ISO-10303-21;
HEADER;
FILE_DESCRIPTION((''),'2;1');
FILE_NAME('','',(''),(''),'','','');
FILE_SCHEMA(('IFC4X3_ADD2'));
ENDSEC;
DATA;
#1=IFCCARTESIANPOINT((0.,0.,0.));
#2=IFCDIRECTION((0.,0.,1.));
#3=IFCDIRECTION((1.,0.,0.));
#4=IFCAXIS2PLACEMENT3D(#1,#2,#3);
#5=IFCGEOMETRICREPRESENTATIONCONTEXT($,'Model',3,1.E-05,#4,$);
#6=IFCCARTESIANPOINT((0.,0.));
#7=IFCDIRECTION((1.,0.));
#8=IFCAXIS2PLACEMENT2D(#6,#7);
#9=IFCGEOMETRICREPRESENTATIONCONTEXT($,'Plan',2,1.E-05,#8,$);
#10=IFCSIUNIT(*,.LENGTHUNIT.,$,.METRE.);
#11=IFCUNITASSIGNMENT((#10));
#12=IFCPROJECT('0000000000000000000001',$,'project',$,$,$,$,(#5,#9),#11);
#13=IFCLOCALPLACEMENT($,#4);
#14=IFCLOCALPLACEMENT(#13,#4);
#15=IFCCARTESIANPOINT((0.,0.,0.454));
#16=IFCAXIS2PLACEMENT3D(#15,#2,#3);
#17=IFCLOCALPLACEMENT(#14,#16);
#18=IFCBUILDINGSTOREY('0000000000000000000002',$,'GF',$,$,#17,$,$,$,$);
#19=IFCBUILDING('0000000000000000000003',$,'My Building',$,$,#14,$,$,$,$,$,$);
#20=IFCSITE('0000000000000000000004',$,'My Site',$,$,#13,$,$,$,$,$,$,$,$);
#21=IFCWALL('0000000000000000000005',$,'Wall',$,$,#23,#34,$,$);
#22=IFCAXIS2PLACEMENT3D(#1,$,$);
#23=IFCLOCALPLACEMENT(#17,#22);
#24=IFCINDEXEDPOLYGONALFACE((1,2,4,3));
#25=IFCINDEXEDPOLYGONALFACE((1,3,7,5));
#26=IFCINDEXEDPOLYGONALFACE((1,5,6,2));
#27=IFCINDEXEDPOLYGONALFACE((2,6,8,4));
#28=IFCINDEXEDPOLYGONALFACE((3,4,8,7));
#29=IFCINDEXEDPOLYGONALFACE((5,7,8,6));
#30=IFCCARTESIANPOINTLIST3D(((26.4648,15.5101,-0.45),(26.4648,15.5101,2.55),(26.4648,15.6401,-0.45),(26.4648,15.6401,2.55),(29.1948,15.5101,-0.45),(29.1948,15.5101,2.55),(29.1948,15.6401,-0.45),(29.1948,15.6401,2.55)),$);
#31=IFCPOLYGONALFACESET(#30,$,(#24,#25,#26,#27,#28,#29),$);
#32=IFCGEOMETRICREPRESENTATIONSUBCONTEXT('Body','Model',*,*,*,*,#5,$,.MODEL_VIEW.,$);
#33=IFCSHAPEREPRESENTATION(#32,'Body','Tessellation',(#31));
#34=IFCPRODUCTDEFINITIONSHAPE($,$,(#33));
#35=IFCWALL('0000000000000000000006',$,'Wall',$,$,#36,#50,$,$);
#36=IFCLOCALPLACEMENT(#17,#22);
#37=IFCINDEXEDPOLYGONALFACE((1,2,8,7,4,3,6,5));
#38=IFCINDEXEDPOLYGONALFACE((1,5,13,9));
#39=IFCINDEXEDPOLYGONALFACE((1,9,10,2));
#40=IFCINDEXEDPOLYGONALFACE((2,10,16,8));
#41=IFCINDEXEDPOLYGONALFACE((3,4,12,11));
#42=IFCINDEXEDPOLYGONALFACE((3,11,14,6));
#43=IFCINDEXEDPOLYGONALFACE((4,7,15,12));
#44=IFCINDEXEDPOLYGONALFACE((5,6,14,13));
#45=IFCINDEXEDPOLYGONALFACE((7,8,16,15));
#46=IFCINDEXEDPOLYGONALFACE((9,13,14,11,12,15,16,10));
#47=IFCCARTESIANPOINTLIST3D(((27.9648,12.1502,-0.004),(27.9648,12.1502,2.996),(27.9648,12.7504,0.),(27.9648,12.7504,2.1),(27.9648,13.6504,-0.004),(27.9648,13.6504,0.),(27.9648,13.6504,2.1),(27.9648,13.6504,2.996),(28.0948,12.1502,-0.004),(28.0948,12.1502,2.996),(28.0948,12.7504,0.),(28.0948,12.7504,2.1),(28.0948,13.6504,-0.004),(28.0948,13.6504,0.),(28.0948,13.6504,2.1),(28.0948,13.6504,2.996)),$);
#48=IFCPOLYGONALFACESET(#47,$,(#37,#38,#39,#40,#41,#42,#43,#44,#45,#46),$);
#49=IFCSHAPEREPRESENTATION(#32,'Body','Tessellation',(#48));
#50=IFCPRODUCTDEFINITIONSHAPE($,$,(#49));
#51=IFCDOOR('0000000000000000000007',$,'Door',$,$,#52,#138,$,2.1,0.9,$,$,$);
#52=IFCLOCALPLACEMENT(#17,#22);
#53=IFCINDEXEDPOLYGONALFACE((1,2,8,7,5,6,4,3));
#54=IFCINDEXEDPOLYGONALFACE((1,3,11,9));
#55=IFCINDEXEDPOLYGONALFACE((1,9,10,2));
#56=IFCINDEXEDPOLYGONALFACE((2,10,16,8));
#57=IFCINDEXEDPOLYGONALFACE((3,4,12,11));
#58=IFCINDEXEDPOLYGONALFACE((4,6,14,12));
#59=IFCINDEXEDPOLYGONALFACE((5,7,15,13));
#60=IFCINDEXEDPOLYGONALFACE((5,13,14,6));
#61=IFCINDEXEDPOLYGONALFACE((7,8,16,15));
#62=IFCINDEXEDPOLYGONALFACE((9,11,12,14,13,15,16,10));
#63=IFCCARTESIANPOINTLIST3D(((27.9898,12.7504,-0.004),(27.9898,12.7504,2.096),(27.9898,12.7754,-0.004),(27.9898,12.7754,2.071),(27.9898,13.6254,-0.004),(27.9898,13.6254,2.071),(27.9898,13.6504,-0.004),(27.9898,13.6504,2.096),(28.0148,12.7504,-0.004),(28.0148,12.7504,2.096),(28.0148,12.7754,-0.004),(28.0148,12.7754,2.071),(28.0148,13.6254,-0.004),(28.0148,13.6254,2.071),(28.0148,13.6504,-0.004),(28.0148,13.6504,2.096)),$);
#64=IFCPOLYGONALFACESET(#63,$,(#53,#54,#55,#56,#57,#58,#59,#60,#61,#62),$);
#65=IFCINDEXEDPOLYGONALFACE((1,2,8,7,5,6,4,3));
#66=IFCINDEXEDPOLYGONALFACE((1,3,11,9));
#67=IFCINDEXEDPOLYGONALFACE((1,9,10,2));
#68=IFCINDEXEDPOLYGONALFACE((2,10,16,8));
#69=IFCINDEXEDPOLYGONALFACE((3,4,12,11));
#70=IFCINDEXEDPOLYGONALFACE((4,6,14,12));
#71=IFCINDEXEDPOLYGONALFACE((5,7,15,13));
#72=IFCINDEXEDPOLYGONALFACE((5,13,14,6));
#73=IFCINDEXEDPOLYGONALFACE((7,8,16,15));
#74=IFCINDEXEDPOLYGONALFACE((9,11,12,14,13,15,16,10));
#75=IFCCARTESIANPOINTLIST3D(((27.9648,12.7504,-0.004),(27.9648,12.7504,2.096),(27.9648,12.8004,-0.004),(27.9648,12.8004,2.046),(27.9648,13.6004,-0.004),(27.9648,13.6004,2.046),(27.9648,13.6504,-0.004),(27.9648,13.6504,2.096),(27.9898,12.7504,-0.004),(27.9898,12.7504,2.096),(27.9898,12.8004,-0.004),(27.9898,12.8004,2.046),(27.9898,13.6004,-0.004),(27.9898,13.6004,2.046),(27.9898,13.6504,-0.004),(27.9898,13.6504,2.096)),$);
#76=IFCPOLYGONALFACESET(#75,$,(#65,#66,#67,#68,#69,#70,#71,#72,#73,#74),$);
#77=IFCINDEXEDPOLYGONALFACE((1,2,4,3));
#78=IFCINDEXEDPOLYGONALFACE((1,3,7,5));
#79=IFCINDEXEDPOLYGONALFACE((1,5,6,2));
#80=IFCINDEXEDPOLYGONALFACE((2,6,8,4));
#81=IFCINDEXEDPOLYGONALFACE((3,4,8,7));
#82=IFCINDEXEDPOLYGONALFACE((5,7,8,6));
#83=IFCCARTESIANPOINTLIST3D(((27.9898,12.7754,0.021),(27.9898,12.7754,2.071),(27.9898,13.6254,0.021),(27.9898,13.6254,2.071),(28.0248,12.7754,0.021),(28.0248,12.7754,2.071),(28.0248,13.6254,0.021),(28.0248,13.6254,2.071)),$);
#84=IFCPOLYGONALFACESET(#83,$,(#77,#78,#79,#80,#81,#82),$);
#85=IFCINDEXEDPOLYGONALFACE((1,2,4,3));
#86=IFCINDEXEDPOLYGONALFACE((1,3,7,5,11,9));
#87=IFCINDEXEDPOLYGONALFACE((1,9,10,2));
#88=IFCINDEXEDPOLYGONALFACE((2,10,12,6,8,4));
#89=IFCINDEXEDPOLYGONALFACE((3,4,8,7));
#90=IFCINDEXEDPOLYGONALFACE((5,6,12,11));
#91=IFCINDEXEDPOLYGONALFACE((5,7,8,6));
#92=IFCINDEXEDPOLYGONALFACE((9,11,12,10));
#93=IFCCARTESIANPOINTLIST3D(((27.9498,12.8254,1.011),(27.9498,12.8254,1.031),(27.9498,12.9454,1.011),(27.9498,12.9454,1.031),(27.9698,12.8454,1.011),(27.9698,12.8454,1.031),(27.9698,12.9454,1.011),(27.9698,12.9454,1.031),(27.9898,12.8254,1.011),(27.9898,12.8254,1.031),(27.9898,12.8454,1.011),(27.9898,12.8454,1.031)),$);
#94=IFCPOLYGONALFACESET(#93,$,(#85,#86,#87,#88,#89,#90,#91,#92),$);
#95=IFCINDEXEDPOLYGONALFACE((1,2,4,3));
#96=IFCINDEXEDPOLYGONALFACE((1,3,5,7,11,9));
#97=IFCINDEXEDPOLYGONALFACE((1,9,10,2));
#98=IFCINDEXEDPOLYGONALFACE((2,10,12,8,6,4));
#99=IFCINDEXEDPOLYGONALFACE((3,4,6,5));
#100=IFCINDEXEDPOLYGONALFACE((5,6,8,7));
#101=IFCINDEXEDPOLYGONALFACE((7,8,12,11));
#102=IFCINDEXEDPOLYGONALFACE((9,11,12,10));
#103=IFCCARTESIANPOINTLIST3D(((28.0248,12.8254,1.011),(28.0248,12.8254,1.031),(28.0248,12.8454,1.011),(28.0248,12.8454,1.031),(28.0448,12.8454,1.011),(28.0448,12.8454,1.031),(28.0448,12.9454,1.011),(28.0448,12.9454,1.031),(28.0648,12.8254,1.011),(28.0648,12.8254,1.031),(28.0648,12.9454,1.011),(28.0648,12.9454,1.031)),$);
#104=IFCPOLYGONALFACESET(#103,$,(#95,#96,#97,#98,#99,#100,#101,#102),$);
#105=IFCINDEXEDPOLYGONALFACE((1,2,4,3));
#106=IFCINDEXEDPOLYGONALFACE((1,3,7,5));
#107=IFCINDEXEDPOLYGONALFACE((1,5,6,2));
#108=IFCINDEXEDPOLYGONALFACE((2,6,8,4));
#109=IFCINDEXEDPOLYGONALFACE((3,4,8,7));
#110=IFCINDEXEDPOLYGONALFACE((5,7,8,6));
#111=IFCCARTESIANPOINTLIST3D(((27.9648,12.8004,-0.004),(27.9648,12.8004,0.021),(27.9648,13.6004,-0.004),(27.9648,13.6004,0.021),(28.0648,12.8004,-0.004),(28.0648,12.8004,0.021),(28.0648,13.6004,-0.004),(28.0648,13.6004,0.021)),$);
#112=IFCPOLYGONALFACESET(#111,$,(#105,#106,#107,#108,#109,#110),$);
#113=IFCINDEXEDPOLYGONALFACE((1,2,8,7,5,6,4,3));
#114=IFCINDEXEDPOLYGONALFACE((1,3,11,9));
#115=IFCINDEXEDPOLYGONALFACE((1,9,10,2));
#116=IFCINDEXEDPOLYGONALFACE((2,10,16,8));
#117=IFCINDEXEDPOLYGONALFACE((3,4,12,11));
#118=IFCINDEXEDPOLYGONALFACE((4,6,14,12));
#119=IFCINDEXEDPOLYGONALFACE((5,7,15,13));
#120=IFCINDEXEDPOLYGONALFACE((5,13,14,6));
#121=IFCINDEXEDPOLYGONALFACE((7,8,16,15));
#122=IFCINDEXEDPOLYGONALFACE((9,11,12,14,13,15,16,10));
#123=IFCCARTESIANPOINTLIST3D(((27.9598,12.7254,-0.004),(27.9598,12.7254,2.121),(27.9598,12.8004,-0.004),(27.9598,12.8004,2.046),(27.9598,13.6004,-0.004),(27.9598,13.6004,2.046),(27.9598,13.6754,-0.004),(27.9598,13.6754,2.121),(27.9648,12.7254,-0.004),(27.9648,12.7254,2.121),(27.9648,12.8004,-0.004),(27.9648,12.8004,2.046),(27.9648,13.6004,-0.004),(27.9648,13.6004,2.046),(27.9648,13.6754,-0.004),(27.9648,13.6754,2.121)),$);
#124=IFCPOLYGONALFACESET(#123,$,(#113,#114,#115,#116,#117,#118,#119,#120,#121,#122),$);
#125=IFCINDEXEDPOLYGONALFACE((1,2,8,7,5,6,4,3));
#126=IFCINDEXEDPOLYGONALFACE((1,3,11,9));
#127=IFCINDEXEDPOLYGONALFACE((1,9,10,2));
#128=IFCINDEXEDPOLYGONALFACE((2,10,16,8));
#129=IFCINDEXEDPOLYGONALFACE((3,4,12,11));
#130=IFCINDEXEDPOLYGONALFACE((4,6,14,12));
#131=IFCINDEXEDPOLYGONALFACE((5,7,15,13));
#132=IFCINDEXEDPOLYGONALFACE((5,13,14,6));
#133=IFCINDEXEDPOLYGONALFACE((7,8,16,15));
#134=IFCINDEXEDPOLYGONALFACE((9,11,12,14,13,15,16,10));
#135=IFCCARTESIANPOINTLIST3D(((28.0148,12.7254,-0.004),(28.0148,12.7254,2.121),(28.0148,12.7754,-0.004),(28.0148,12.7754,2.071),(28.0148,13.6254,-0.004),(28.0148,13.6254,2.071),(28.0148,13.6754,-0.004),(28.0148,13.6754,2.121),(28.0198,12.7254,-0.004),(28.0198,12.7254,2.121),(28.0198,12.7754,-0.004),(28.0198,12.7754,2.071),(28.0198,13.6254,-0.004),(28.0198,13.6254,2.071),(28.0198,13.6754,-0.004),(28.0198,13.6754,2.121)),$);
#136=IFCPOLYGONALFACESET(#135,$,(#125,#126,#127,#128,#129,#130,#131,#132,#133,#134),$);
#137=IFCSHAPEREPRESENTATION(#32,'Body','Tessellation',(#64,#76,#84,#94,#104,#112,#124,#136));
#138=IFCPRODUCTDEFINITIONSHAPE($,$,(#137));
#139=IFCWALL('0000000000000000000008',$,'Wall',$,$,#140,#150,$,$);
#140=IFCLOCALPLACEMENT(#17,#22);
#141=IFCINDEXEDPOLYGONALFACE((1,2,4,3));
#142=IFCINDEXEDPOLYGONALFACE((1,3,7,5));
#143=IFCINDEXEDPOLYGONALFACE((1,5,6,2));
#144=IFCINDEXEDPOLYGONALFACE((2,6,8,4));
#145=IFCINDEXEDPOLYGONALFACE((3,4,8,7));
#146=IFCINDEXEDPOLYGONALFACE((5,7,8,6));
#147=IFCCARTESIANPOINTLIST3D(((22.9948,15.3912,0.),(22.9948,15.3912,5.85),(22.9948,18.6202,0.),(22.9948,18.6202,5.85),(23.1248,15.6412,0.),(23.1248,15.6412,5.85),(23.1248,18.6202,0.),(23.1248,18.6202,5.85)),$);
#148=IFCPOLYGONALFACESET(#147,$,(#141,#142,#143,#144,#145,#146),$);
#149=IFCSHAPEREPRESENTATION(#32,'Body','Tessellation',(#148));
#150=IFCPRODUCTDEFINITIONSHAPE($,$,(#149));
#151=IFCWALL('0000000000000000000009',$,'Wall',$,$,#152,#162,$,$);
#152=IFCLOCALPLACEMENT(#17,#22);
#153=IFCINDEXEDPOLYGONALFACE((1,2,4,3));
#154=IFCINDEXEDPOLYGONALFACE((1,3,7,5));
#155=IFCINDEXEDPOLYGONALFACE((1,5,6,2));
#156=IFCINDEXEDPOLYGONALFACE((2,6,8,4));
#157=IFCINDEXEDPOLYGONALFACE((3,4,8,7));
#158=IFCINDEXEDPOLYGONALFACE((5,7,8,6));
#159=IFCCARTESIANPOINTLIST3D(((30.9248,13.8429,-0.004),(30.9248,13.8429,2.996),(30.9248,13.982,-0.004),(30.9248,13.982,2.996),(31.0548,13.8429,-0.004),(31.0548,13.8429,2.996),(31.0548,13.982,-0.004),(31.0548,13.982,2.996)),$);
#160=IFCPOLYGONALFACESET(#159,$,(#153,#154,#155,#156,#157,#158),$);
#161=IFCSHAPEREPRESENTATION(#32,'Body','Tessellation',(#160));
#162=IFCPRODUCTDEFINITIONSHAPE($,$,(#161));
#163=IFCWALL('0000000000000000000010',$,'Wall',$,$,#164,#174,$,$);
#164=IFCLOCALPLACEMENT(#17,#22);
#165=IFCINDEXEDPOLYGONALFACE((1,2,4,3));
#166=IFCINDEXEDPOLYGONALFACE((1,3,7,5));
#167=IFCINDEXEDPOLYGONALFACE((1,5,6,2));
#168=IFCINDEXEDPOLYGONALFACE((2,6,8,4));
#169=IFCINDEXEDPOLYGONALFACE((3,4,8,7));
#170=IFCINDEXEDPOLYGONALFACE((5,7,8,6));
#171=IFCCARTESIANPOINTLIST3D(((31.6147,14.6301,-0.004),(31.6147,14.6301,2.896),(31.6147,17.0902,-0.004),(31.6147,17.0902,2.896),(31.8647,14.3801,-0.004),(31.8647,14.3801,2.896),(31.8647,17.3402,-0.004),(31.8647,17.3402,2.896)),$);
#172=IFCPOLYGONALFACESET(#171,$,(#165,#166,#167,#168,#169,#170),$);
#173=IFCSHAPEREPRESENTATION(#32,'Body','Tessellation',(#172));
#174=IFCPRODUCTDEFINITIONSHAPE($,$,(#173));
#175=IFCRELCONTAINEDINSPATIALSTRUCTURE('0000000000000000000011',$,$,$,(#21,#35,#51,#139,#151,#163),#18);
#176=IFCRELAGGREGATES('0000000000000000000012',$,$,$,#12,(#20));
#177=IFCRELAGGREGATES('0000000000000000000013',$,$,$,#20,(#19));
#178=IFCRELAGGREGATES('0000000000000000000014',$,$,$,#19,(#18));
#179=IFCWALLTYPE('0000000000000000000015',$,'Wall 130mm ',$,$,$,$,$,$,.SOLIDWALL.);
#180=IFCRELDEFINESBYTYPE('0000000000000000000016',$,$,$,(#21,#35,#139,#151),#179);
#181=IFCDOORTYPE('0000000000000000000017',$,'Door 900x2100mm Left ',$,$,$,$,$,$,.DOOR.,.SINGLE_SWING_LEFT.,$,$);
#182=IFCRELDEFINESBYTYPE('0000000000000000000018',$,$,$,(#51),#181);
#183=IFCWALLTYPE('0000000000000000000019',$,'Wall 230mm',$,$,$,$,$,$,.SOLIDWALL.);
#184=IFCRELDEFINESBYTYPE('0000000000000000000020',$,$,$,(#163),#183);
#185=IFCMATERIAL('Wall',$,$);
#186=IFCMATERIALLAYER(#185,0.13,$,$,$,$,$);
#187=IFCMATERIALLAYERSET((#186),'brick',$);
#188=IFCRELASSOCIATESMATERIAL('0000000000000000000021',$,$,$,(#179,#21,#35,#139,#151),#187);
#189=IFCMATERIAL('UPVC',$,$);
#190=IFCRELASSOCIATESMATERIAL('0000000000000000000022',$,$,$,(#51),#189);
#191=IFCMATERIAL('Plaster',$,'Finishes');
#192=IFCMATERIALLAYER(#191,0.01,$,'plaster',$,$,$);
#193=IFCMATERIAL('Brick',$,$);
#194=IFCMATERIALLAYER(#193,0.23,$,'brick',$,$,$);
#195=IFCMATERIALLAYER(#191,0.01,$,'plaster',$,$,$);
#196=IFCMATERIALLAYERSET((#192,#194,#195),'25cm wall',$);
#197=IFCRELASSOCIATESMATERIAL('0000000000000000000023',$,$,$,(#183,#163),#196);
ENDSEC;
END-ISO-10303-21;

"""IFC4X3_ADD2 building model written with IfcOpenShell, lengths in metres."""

from ifc_helpers import new_model, entity, si_unit, frame, origin_with_axes, origin_2d_with_axis, place, context, subcontext, project, spatial, line, indexed_curve, outline, extrude, shape, source, transform, mapped, material, layer, layer_set, layer_usage, type_object, type_shapes, element, fill, save


model = new_model("IFC4X3_ADD2")

# Units and contexts
model_context = context("Model", 3, precision=1e-05, world=origin_with_axes())
plan_context = context("Plan", 2, precision=1e-05, world=origin_2d_with_axis())
body_context_1 = subcontext(model_context, "Body", "Model", "MODEL_VIEW")
body_context_2 = subcontext(plan_context, "Body", "Plan", "PLAN_VIEW")
ifc_project = project(units=[si_unit("LENGTHUNIT", "METRE")], contexts=[model_context, plan_context])

# Site, building, storey
site_placement = place(None, origin_with_axes())
site = spatial("IfcSite", under=ifc_project, at=site_placement, Name="My Site")
building_placement = place(site_placement, origin_with_axes())
building = spatial("IfcBuilding", under=site, at=building_placement, Name="My Building")
storey_placement = place(building_placement, frame((0.0, 0.0, 0.454), z_axis=(0.0, 0.0, 1.0), x_axis=(1.0, 0.0, 0.0)))
storey = spatial("IfcBuildingStorey", under=building, at=storey_placement, Name="GF")

# Wall
ifc_material_1 = material(Name="Wall")
ifc_layer_1 = layer(ifc_material_1, 0.13)
ifc_layer_set_1 = layer_set([ifc_layer_1], Name="brick")
wall_type_1 = type_object("IfcWallType", Name="Wall 130mm ", PredefinedType="SOLIDWALL", material=ifc_layer_set_1)
ifc_layer_usage_1 = layer_usage(ifc_layer_set_1, "AXIS2", "POSITIVE", 0.0)
wall_1_placement = place(storey_placement, frame((29.1948, 15.6401, -0.45), z_axis=(0.0, 0.0, 1.0), x_axis=(-1.0, 0.0, 0.0)))
element("IfcWall", 1, at=wall_1_placement, inside=storey, type_object=wall_type_1, material=ifc_layer_usage_1, Name="Wall", context=body_context_1, shape_type="SweptSolid", body=[
    extrude(outline(indexed_curve([(0.0, 0.0), (0.0, 0.13), (2.73, 0.13), (2.73, 0.0), (0.0, 0.0)], self_intersect=False)), origin_with_axes(), (0.0, 0.0, 1.0), 3.0),
])

# Wall, opening, door
ifc_layer_usage_2 = layer_usage(ifc_layer_set_1, "AXIS2", "POSITIVE", 0.0)
wall_2_placement = place(storey_placement, frame((27.9648, 13.6504, -0.004), z_axis=(0.0, 0.0, 1.0), x_axis=(0.0, -1.0, 0.0)))
wall_2 = element("IfcWall", 2, at=wall_2_placement, inside=storey, type_object=wall_type_1, material=ifc_layer_usage_2, Name="Wall", context=body_context_1, shape_type="SweptSolid", body=[
    extrude(outline(indexed_curve([(0.0, 0.0), (0.0, 0.13), (1.5002, 0.13), (1.5002, 0.0), (0.0, 0.0)], self_intersect=False)), origin_with_axes(), (0.0, 0.0, 1.0), 3.0),
])
shared_shape_1 = source(origin_with_axes(), body_context_1, "Body", "SweptSolid", [
    extrude(outline(indexed_curve([(0.0, 0.0), (0.9, 0.0), (0.9, 2.1), (0.0, 2.1)], segments=[line(1, 2, 3, 4, 1)])), frame((0.0, -0.6, 0.0), z_axis=(0.0, -1.0, 0.0), x_axis=(1.0, 0.0, 0.0)), (0.0, 0.0, -1.0), 1.2),
])
opening_1_placement = place(wall_2_placement, frame((0.0, 0.0, 0.004), z_axis=(0.0, 0.0, 1.0), x_axis=(1.0, 0.0, 0.0)))
opening_1 = element("IfcOpeningElement", 3, at=opening_1_placement, cuts=wall_2, PredefinedType="OPENING", context=body_context_1, shape_type="MappedRepresentation", body=[
    mapped(shared_shape_1, transform((0.0, 0.0, 0.0), x_axis=(1.0, 0.0, 0.0), y_axis=(0.0, 1.0, 0.0), z_axis=(0.0, 0.0, 1.0), scale=1.0)),
])
ifc_material_2 = material(Name="UPVC")
door_type_1 = type_object("IfcDoorType", Name="Door 900x2100mm Left ", OperationType="SINGLE_SWING_LEFT", PredefinedType="DOOR")
shared_shape_2 = source(origin_with_axes(), body_context_1, "Body", "SweptSolid", [
    extrude(outline(indexed_curve([(0.0, 0.0), (0.0, 2.1), (0.9, 2.1), (0.9, 0.0), (0.875, 0.0), (0.875, 2.075), (0.025, 2.075), (0.025, 0.0)], segments=[line(1, 2, 3, 4, 5, 6, 7, 8, 1)])), frame((0.0, 0.025, 0.0), z_axis=(0.0, -1.0, 0.0), x_axis=(1.0, 0.0, 0.0)), (0.0, 0.0, -1.0), 0.025),
    extrude(outline(indexed_curve([(0.0, 0.0), (0.0, 2.1), (0.9, 2.1), (0.9, 0.0), (0.85, 0.0), (0.85, 2.05), (0.05, 2.05), (0.05, 0.0)], segments=[line(1, 2, 3, 4, 5, 6, 7, 8, 1)])), frame((0.0, 0.0, 0.0), z_axis=(0.0, -1.0, 0.0), x_axis=(1.0, 0.0, 0.0)), (0.0, 0.0, -1.0), 0.025),
    extrude(outline(indexed_curve([(0.0, 0.0), (0.85, 0.0), (0.85, 0.035), (0.0, 0.035)], segments=[line(1, 2, 3, 4, 1)])), frame((0.025, 0.025, 0.025), z_axis=(0.0, 0.0, 1.0), x_axis=(1.0, 0.0, 0.0)), (0.0, 0.0, 1.0), 2.05),
    extrude(outline(indexed_curve([(0.0, 0.0), (0.0, -0.04), (-0.12, -0.04), (-0.12, -0.02), (-0.02, -0.02), (-0.02, 0.0)], segments=[line(1, 2, 3, 4, 5, 6, 1)])), frame((0.825, 0.025, 1.015), z_axis=(0.0, 0.0, 1.0), x_axis=(1.0, 0.0, 0.0)), (0.0, 0.0, 1.0), 0.02),
    extrude(outline(indexed_curve([(0.0, 0.0), (0.0, 0.04), (-0.12, 0.04), (-0.12, 0.02), (-0.02, 0.02), (-0.02, 0.0)], segments=[line(1, 2, 3, 4, 5, 6, 1)])), frame((0.825, 0.06, 1.015), z_axis=(0.0, 0.0, 1.0), x_axis=(1.0, 0.0, 0.0)), (0.0, 0.0, 1.0), 0.02),
    extrude(outline(indexed_curve([(0.0, 0.0), (0.8, 0.0), (0.8, 0.1), (0.0, 0.1)], segments=[line(1, 2, 3, 4, 1)])), frame((0.05, 0.0, 0.0), z_axis=(0.0, 0.0, 1.0), x_axis=(1.0, 0.0, 0.0)), (0.0, 0.0, 1.0), 0.025),
    extrude(outline(indexed_curve([(0.0, 0.0), (0.0, 2.125), (0.95, 2.125), (0.95, 0.0), (0.875, 0.0), (0.875, 2.05), (0.075, 2.05), (0.075, 0.0)], segments=[line(1, 2, 3, 4, 5, 6, 7, 8, 1)])), frame((-0.025, -0.005, 0.0), z_axis=(0.0, -1.0, 0.0), x_axis=(1.0, 0.0, 0.0)), (0.0, 0.0, -1.0), 0.005),
    extrude(outline(indexed_curve([(0.0, 0.0), (0.0, 2.125), (0.95, 2.125), (0.95, 0.0), (0.9, 0.0), (0.9, 2.075), (0.05, 2.075), (0.05, 0.0)], segments=[line(1, 2, 3, 4, 5, 6, 7, 8, 1)])), frame((-0.025, 0.05, 0.0), z_axis=(0.0, -1.0, 0.0), x_axis=(1.0, 0.0, 0.0)), (0.0, 0.0, -1.0), 0.005),
])
shared_shape_3 = source(origin_with_axes(), body_context_2, "Body", "Curve2D", [
    entity("IfcIndexedPolyCurve", entity("IfcCartesianPointList2D", [[0.0, 0.0], [0.0, 0.05], [0.025, 0.05], [0.025, 0.025], [0.05, 0.025], [0.05, 0.0]]), [entity("IfcLineIndex", [1, 2, 3, 4, 5, 6, 1])]),
    entity("IfcIndexedPolyCurve", entity("IfcCartesianPointList2D", [[0.9, 0.0], [0.9, 0.05], [0.875, 0.05], [0.875, 0.025], [0.85, 0.025], [0.85, 0.0]]), [entity("IfcLineIndex", [1, 2, 3, 4, 5, 6, 1])]),
    entity("IfcTrimmedCurve", entity("IfcEllipse", entity("IfcAxis2Placement2D", entity("IfcCartesianPoint", [0.06, 0.05]), entity("IfcDirection", [1.0, 0.0])), 0.815, 0.85), [entity("IfcCartesianPoint", [0.875, 0.05])], [entity("IfcCartesianPoint", [0.06, 0.9])], True, "CARTESIAN"),
    entity("IfcIndexedPolyCurve", entity("IfcCartesianPointList2D", [[0.025, 0.05], [0.06, 0.05], [0.06, 0.9], [0.025, 0.9]]), [entity("IfcLineIndex", [1, 2, 3, 4, 1])]),
])
type_shapes(door_type_1, [shared_shape_2, shared_shape_3])
door_1_placement = place(opening_1_placement, frame((0.0, 0.0, -0.004), z_axis=(0.0, 0.0, 1.0), x_axis=(1.0, 0.0, 0.0)))
door_1 = element("IfcDoor", 4, at=door_1_placement, inside=storey, type_object=door_type_1, material=ifc_material_2, Name="Door", OverallHeight=2.1, OverallWidth=0.9, shapes=[
    shape(body_context_1, "Body", "MappedRepresentation", [mapped(shared_shape_2, transform((0.0, 0.0, 0.0), x_axis=(1.0, 0.0, 0.0), y_axis=(0.0, 1.0, 0.0), z_axis=(0.0, 0.0, 1.0), scale=1.0))]),
    shape(body_context_2, "Body", "MappedRepresentation", [mapped(shared_shape_3, transform((0.0, 0.0, 0.0), x_axis=(1.0, 0.0, 0.0), y_axis=(0.0, 1.0, 0.0), z_axis=(0.0, 0.0, 1.0), scale=1.0))]),
])
fill(opening_1, door_1)

# Walls
ifc_layer_usage_3 = layer_usage(ifc_layer_set_1, "AXIS2", "POSITIVE", 0.0)
wall_3_placement = place(storey_placement, frame((23.1248, 15.6412, 0.0), z_axis=(0.0, 0.0, 1.0), x_axis=(0.000001, 1.0, 0.0)))
element("IfcWall", 5, at=wall_3_placement, inside=storey, type_object=wall_type_1, material=ifc_layer_usage_3, Name="Wall", context=body_context_1, shape_type="SweptSolid", body=[
    extrude(outline(indexed_curve([(0.0, 0.0), (-0.25, 0.13), (2.979, 0.13), (2.979, 0.0)], segments=[line(1, 2, 3, 4, 1)])), origin_with_axes(), (0.0, 0.0, 1.0), 5.85),
])
ifc_layer_usage_4 = layer_usage(ifc_layer_set_1, "AXIS2", "NEGATIVE", 0.0)
wall_4_placement = place(storey_placement, frame((30.9248, 13.8429, -0.004), z_axis=(0.0, 0.0, 1.0), x_axis=(0.000001, 1.0, 0.0)))
element("IfcWall", 6, at=wall_4_placement, inside=storey, type_object=wall_type_1, material=ifc_layer_usage_4, Name="Wall", context=body_context_1, shape_type="SweptSolid", body=[
    extrude(outline(indexed_curve([(0.0, -0.13), (0.0, 0.0), (0.1391, 0.0), (0.1391, -0.13)], segments=[line(1, 2, 3, 4, 1)])), origin_with_axes(), (0.0, 0.0, 1.0), 3.0),
])
ifc_material_3 = material(Name="Plaster", Category="Finishes")
ifc_layer_2 = layer(ifc_material_3, 0.01, Name="plaster")
ifc_material_4 = material(Name="Brick")
ifc_layer_3 = layer(ifc_material_4, 0.23, Name="brick")
ifc_layer_4 = layer(ifc_material_3, 0.01, Name="plaster")
ifc_layer_set_2 = layer_set([ifc_layer_2, ifc_layer_3, ifc_layer_4], Name="25cm wall")
ifc_layer_usage_5 = layer_usage(ifc_layer_set_2, "AXIS2", "POSITIVE", 0.0)
wall_type_2 = type_object("IfcWallType", Name="Wall 230mm", PredefinedType="SOLIDWALL", material=ifc_layer_set_2)
wall_5_placement = place(storey_placement, frame((31.8647, 14.3801, -0.004), z_axis=(0.0, 0.0, 1.0), x_axis=(0.000001, 1.0, 0.0)))
element("IfcWall", 7, at=wall_5_placement, inside=storey, type_object=wall_type_2, material=ifc_layer_usage_5, Name="Wall", context=body_context_1, shape_type="SweptSolid", body=[
    extrude(outline(indexed_curve([(0.0, 0.0), (0.25, 0.25), (2.71, 0.25), (2.96, 0.0)], segments=[line(1, 2, 3, 4, 1)])), origin_with_axes(), (0.0, 0.0, 1.0), 2.9),
])

save(model, "model.ifc")
